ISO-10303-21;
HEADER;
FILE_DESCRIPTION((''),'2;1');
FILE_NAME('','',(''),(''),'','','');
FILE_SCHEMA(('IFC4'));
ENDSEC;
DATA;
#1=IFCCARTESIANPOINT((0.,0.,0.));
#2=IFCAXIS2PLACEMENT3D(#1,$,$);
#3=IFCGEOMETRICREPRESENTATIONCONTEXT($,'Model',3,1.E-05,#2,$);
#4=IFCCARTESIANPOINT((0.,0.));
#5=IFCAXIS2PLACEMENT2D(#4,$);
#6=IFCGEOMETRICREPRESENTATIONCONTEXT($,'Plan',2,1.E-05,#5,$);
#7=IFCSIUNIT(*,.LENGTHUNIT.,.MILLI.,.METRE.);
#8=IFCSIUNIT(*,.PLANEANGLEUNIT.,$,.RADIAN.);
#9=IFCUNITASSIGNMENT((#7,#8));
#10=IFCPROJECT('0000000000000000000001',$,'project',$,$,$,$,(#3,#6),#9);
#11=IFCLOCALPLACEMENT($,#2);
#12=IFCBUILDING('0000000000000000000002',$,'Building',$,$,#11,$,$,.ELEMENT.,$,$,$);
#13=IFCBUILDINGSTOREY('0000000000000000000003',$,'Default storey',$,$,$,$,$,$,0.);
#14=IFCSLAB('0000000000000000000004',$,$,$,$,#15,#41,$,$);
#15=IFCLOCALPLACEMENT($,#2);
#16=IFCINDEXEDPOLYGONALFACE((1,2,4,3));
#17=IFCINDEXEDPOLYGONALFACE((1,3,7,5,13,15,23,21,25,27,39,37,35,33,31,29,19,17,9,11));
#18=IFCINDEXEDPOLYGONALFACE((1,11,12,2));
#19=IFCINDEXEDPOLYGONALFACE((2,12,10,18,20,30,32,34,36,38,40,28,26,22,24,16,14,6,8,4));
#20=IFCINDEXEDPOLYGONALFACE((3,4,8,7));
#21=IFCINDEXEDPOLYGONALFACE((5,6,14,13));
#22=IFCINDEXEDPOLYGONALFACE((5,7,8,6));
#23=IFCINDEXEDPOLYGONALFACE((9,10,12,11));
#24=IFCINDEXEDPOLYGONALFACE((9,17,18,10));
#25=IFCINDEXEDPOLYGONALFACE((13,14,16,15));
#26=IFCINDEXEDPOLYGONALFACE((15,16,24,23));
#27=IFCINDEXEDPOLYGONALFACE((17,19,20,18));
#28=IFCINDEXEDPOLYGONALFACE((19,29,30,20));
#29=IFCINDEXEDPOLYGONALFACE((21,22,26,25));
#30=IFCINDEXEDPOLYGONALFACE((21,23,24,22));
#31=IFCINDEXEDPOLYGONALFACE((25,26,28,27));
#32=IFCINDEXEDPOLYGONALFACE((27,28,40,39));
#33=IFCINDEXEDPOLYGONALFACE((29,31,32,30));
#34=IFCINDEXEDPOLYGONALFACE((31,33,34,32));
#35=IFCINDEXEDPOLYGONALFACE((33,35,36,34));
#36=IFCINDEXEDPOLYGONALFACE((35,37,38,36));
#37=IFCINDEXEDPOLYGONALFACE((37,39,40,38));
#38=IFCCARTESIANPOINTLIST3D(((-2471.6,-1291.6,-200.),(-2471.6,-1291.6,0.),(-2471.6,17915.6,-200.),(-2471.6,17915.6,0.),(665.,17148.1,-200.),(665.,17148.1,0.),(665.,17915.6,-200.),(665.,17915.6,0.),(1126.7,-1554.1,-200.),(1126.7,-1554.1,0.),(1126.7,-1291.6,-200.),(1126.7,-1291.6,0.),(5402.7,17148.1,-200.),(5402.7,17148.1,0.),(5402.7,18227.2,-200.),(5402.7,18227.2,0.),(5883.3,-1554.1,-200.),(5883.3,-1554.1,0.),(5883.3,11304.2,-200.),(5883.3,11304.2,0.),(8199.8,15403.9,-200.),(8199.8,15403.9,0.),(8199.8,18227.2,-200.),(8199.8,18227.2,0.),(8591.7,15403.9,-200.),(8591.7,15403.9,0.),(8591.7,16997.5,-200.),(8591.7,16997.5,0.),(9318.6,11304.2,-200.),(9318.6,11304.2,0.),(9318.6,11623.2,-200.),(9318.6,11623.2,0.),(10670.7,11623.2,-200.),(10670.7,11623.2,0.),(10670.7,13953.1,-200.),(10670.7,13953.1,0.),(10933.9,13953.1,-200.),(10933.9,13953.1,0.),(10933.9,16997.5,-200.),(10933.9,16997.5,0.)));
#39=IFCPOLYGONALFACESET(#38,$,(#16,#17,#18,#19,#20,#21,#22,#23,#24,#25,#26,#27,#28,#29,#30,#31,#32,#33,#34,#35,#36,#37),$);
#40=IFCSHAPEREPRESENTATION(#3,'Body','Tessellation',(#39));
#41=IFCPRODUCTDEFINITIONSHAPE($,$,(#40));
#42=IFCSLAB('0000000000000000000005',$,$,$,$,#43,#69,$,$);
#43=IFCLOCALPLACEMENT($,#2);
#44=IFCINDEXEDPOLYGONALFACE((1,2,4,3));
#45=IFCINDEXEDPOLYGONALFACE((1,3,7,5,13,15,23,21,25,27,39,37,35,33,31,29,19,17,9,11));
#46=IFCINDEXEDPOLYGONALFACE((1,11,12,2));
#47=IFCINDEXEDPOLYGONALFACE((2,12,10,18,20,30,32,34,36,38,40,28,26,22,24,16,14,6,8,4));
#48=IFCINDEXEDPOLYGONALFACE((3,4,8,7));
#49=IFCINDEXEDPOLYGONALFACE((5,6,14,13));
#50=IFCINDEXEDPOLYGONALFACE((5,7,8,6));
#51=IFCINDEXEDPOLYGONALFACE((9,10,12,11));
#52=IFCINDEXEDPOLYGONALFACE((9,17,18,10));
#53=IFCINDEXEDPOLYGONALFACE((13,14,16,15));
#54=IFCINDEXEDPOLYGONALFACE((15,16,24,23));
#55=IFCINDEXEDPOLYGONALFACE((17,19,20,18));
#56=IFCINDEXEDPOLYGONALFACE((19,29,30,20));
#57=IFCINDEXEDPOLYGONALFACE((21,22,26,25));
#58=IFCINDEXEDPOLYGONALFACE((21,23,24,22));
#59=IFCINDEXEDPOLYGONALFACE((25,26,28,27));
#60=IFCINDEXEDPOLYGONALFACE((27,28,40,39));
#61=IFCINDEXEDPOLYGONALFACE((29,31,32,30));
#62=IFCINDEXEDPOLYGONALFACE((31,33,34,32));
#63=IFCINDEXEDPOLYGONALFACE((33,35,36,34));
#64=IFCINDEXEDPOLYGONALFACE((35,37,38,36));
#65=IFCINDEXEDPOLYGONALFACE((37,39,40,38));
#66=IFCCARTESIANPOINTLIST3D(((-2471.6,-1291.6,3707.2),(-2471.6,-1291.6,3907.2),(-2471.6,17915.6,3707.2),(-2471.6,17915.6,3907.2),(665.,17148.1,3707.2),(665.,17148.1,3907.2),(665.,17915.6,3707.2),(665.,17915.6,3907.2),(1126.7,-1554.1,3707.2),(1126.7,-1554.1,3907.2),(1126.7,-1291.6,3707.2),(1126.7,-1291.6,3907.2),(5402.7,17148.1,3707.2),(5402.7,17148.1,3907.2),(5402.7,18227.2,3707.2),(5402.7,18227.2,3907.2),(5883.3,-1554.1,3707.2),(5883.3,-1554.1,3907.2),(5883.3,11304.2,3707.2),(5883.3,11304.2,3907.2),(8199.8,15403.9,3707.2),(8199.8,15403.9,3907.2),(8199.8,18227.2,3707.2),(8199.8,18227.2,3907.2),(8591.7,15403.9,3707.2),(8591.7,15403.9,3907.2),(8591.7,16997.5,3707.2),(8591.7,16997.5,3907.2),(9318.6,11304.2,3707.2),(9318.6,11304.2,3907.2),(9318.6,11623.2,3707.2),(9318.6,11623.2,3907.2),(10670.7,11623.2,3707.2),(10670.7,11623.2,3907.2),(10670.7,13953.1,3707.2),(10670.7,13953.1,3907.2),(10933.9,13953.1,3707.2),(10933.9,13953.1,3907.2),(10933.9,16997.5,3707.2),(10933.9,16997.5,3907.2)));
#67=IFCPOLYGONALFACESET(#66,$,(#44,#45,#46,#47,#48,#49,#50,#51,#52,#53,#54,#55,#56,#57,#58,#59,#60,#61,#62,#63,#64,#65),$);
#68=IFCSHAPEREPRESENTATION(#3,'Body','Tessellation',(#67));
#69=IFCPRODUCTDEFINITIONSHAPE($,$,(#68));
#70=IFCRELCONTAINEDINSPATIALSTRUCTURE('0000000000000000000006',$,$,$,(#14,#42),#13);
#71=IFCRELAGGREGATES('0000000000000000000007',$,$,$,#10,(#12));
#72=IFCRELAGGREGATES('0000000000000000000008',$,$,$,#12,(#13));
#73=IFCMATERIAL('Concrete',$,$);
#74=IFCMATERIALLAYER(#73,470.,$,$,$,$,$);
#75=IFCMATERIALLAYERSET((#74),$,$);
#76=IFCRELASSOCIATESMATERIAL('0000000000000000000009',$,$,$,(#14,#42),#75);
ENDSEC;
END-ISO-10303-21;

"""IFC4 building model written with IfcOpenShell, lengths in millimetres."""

from ifc_helpers import new_model, si_unit, frame, origin, origin_2d, place, context, project, spatial, polyline, outline, extrude, material, layer, layer_set, layer_usage, element, save


model = new_model("IFC4")

# Units and contexts
model_context = context("Model", 3, precision=1e-05, world=origin())
plan_context = context("Plan", 2, precision=1e-05, world=origin_2d())
ifc_project = project(units=[si_unit("LENGTHUNIT", "METRE", prefix="MILLI"), si_unit("PLANEANGLEUNIT", "RADIAN")], contexts=[model_context, plan_context])

# Building, storey
placement = place(None, origin())
building = spatial("IfcBuilding", under=ifc_project, at=placement, Name="Building", CompositionType="ELEMENT")
storey = spatial("IfcBuildingStorey", under=building, Name="Default storey", Elevation=0.0)

# Slabs
ifc_material_1 = material(Name="Concrete")
ifc_layer = layer(ifc_material_1, 470.0)
ifc_layer_set = layer_set([ifc_layer])
ifc_layer_usage = layer_usage(ifc_layer_set, "AXIS3", "POSITIVE", 0.0)
element("IfcSlab", 1, at=placement, inside=storey, material=ifc_layer_usage, context=model_context, shape_type="SweptSolid", body=[
    extrude(outline(polyline([(8591.7, 16997.5), (8591.7, 15403.9), (8199.8, 15403.9), (8199.8, 18227.2), (5402.7, 18227.2), (5402.7, 17148.1), (665.0, 17148.1), (665.0, 17915.6), (-2471.6, 17915.6), (-2471.6, -1291.6), (1126.7, -1291.6), (1126.7, -1554.1), (5883.3, -1554.1), (5883.3, 11304.2), (9318.6, 11304.2), (9318.6, 11623.2), (10670.7, 11623.2), (10670.7, 13953.1), (10933.9, 13953.1), (10933.9, 16997.5), (8591.7, 16997.5)])), frame((0.0, 0.0, -200.0), z_axis=(0.0, 0.0, 1000.0), x_axis=(1000.0, 0.0, 0.0)), (0.0, 0.0, 1.0), 200.0),
])
element("IfcSlab", 2, at=placement, inside=storey, material=ifc_layer_usage, context=model_context, shape_type="SweptSolid", body=[
    extrude(outline(polyline([(8591.7, 16997.5), (8591.7, 15403.9), (8199.8, 15403.9), (8199.8, 18227.2), (5402.7, 18227.2), (5402.7, 17148.1), (665.0, 17148.1), (665.0, 17915.6), (-2471.6, 17915.6), (-2471.6, -1291.6), (1126.7, -1291.6), (1126.7, -1554.1), (5883.3, -1554.1), (5883.3, 11304.2), (9318.6, 11304.2), (9318.6, 11623.2), (10670.7, 11623.2), (10670.7, 13953.1), (10933.9, 13953.1), (10933.9, 16997.5), (8591.7, 16997.5)])), frame((0.0, 0.0, 3907.2), z_axis=(0.0, 0.0, 1000.0), x_axis=(1000.0, 0.0, 0.0)), (0.0, 0.0, -1.0), 200.0),
])

save(model, "model.ifc")
